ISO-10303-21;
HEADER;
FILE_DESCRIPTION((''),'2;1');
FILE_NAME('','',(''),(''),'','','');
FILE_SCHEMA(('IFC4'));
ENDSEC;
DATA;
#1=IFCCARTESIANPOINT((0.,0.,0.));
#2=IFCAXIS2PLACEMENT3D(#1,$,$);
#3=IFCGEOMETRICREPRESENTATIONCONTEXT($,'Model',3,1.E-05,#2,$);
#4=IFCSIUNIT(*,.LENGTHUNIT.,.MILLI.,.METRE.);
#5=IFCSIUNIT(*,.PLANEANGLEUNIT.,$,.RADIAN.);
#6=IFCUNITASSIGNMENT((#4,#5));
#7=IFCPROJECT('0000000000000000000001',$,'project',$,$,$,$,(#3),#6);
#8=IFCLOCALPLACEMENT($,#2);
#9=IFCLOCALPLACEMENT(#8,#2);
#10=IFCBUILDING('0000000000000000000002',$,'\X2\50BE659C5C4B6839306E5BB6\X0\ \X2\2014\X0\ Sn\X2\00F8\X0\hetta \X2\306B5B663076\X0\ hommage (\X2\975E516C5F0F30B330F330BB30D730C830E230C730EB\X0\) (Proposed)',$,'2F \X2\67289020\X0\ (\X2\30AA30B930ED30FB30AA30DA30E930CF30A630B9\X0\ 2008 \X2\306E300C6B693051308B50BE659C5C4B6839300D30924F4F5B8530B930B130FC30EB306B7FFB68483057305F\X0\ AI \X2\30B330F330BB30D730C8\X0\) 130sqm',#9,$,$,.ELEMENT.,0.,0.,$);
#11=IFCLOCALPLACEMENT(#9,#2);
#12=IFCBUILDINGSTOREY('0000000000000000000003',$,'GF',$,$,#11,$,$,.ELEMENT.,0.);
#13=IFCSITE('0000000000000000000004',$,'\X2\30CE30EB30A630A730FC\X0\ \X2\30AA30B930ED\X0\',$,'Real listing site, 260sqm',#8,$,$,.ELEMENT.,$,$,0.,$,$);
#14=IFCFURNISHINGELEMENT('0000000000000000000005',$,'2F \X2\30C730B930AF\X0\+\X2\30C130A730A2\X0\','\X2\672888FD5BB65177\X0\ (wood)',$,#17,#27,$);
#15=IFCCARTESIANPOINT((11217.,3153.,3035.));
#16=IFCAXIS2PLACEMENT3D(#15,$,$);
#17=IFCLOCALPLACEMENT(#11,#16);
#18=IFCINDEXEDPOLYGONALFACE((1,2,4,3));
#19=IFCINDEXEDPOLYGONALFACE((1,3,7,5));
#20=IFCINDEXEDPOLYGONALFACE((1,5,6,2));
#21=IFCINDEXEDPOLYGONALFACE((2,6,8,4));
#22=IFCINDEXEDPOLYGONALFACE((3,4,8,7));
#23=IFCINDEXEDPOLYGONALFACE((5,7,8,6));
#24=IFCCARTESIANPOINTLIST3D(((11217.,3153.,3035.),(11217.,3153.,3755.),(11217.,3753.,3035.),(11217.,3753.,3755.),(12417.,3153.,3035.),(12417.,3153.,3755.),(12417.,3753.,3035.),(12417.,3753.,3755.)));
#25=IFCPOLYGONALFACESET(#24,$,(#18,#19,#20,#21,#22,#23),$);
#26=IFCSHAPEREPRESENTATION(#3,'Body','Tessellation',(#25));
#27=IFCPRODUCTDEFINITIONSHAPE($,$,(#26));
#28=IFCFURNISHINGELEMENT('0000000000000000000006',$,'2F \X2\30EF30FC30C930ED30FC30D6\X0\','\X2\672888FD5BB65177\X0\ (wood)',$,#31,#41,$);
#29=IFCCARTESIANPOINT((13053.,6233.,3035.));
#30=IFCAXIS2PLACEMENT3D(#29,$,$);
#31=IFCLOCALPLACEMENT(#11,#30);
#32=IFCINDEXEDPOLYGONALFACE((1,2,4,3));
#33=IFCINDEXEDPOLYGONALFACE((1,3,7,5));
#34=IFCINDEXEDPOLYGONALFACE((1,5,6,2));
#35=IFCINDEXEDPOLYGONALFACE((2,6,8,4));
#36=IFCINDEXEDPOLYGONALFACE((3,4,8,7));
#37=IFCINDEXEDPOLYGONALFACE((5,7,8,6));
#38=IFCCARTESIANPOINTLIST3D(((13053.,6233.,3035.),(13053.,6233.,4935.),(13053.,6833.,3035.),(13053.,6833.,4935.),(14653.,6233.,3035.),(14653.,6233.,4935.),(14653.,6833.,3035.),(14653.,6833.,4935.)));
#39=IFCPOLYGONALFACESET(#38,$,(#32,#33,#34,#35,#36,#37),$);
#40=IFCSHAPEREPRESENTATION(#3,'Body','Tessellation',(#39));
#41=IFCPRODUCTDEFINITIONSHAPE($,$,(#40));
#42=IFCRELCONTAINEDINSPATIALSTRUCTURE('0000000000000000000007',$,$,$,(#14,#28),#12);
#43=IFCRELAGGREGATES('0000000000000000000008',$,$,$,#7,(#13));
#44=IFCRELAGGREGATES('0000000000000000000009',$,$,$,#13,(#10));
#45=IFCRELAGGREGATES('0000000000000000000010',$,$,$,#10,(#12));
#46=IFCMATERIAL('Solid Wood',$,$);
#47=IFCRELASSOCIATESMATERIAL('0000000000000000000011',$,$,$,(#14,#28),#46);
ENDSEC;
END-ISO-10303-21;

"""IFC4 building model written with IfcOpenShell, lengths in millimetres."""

from ifc_helpers import new_model, si_unit, frame, frame_2d, origin, place, context, project, spatial, rectangle, extrude, material, element, save


model = new_model("IFC4")

# Units and contexts
model_context = context("Model", 3, precision=1e-05, world=origin())
ifc_project = project(units=[si_unit("LENGTHUNIT", "METRE", prefix="MILLI"), si_unit("PLANEANGLEUNIT", "RADIAN")], contexts=[model_context])

# Site, building, storey
site_placement = place(None, origin())
site = spatial("IfcSite", under=ifc_project, at=site_placement, Name="ノルウェー オスロ", ObjectType="Real listing site, 260sqm", CompositionType="ELEMENT", RefElevation=0.0)
building_placement = place(site_placement, origin())
building = spatial("IfcBuilding", under=site, at=building_placement, Name="傾斜屋根の家 — Snøhetta に学ぶ hommage (非公式コンセプトモデル) (Proposed)", ObjectType="2F 木造 (オスロ・オペラハウス 2008 の「歩ける傾斜屋根」を住宅スケールに翻案した AI コンセプト) 130sqm", CompositionType="ELEMENT", ElevationOfRefHeight=0.0, ElevationOfTerrain=0.0)
storey_placement = place(building_placement, origin())
storey = spatial("IfcBuildingStorey", under=building, at=storey_placement, Name="GF", CompositionType="ELEMENT", Elevation=0.0)

# Shared definitions
ifc_material_1 = material(Name="Solid Wood")

# Furnishing elements
furnishing_1_placement = place(storey_placement, frame((11217.0, 3153.0, 3035.0)))
element("IfcFurnishingElement", 1, at=furnishing_1_placement, inside=storey, material=ifc_material_1, Name="2F デスク+チェア", Description="木製家具 (wood)", context=model_context, shape_type="SweptSolid", body=[
    extrude(rectangle(XDim=1200.0, YDim=600.0, at=frame_2d((600.0, 300.0))), frame((11217.0, 3153.0, 3035.0)), (0.0, 0.0, 1.0), 720.0),
])
furnishing_2_placement = place(storey_placement, frame((13053.0, 6233.0, 3035.0)))
element("IfcFurnishingElement", 2, at=furnishing_2_placement, inside=storey, material=ifc_material_1, Name="2F ワードローブ", Description="木製家具 (wood)", context=model_context, shape_type="SweptSolid", body=[
    extrude(rectangle(XDim=1600.0, YDim=600.0, at=frame_2d((800.0, 300.0))), frame((13053.0, 6233.0, 3035.0)), (0.0, 0.0, 1.0), 1900.0),
])

save(model, "model.ifc")
